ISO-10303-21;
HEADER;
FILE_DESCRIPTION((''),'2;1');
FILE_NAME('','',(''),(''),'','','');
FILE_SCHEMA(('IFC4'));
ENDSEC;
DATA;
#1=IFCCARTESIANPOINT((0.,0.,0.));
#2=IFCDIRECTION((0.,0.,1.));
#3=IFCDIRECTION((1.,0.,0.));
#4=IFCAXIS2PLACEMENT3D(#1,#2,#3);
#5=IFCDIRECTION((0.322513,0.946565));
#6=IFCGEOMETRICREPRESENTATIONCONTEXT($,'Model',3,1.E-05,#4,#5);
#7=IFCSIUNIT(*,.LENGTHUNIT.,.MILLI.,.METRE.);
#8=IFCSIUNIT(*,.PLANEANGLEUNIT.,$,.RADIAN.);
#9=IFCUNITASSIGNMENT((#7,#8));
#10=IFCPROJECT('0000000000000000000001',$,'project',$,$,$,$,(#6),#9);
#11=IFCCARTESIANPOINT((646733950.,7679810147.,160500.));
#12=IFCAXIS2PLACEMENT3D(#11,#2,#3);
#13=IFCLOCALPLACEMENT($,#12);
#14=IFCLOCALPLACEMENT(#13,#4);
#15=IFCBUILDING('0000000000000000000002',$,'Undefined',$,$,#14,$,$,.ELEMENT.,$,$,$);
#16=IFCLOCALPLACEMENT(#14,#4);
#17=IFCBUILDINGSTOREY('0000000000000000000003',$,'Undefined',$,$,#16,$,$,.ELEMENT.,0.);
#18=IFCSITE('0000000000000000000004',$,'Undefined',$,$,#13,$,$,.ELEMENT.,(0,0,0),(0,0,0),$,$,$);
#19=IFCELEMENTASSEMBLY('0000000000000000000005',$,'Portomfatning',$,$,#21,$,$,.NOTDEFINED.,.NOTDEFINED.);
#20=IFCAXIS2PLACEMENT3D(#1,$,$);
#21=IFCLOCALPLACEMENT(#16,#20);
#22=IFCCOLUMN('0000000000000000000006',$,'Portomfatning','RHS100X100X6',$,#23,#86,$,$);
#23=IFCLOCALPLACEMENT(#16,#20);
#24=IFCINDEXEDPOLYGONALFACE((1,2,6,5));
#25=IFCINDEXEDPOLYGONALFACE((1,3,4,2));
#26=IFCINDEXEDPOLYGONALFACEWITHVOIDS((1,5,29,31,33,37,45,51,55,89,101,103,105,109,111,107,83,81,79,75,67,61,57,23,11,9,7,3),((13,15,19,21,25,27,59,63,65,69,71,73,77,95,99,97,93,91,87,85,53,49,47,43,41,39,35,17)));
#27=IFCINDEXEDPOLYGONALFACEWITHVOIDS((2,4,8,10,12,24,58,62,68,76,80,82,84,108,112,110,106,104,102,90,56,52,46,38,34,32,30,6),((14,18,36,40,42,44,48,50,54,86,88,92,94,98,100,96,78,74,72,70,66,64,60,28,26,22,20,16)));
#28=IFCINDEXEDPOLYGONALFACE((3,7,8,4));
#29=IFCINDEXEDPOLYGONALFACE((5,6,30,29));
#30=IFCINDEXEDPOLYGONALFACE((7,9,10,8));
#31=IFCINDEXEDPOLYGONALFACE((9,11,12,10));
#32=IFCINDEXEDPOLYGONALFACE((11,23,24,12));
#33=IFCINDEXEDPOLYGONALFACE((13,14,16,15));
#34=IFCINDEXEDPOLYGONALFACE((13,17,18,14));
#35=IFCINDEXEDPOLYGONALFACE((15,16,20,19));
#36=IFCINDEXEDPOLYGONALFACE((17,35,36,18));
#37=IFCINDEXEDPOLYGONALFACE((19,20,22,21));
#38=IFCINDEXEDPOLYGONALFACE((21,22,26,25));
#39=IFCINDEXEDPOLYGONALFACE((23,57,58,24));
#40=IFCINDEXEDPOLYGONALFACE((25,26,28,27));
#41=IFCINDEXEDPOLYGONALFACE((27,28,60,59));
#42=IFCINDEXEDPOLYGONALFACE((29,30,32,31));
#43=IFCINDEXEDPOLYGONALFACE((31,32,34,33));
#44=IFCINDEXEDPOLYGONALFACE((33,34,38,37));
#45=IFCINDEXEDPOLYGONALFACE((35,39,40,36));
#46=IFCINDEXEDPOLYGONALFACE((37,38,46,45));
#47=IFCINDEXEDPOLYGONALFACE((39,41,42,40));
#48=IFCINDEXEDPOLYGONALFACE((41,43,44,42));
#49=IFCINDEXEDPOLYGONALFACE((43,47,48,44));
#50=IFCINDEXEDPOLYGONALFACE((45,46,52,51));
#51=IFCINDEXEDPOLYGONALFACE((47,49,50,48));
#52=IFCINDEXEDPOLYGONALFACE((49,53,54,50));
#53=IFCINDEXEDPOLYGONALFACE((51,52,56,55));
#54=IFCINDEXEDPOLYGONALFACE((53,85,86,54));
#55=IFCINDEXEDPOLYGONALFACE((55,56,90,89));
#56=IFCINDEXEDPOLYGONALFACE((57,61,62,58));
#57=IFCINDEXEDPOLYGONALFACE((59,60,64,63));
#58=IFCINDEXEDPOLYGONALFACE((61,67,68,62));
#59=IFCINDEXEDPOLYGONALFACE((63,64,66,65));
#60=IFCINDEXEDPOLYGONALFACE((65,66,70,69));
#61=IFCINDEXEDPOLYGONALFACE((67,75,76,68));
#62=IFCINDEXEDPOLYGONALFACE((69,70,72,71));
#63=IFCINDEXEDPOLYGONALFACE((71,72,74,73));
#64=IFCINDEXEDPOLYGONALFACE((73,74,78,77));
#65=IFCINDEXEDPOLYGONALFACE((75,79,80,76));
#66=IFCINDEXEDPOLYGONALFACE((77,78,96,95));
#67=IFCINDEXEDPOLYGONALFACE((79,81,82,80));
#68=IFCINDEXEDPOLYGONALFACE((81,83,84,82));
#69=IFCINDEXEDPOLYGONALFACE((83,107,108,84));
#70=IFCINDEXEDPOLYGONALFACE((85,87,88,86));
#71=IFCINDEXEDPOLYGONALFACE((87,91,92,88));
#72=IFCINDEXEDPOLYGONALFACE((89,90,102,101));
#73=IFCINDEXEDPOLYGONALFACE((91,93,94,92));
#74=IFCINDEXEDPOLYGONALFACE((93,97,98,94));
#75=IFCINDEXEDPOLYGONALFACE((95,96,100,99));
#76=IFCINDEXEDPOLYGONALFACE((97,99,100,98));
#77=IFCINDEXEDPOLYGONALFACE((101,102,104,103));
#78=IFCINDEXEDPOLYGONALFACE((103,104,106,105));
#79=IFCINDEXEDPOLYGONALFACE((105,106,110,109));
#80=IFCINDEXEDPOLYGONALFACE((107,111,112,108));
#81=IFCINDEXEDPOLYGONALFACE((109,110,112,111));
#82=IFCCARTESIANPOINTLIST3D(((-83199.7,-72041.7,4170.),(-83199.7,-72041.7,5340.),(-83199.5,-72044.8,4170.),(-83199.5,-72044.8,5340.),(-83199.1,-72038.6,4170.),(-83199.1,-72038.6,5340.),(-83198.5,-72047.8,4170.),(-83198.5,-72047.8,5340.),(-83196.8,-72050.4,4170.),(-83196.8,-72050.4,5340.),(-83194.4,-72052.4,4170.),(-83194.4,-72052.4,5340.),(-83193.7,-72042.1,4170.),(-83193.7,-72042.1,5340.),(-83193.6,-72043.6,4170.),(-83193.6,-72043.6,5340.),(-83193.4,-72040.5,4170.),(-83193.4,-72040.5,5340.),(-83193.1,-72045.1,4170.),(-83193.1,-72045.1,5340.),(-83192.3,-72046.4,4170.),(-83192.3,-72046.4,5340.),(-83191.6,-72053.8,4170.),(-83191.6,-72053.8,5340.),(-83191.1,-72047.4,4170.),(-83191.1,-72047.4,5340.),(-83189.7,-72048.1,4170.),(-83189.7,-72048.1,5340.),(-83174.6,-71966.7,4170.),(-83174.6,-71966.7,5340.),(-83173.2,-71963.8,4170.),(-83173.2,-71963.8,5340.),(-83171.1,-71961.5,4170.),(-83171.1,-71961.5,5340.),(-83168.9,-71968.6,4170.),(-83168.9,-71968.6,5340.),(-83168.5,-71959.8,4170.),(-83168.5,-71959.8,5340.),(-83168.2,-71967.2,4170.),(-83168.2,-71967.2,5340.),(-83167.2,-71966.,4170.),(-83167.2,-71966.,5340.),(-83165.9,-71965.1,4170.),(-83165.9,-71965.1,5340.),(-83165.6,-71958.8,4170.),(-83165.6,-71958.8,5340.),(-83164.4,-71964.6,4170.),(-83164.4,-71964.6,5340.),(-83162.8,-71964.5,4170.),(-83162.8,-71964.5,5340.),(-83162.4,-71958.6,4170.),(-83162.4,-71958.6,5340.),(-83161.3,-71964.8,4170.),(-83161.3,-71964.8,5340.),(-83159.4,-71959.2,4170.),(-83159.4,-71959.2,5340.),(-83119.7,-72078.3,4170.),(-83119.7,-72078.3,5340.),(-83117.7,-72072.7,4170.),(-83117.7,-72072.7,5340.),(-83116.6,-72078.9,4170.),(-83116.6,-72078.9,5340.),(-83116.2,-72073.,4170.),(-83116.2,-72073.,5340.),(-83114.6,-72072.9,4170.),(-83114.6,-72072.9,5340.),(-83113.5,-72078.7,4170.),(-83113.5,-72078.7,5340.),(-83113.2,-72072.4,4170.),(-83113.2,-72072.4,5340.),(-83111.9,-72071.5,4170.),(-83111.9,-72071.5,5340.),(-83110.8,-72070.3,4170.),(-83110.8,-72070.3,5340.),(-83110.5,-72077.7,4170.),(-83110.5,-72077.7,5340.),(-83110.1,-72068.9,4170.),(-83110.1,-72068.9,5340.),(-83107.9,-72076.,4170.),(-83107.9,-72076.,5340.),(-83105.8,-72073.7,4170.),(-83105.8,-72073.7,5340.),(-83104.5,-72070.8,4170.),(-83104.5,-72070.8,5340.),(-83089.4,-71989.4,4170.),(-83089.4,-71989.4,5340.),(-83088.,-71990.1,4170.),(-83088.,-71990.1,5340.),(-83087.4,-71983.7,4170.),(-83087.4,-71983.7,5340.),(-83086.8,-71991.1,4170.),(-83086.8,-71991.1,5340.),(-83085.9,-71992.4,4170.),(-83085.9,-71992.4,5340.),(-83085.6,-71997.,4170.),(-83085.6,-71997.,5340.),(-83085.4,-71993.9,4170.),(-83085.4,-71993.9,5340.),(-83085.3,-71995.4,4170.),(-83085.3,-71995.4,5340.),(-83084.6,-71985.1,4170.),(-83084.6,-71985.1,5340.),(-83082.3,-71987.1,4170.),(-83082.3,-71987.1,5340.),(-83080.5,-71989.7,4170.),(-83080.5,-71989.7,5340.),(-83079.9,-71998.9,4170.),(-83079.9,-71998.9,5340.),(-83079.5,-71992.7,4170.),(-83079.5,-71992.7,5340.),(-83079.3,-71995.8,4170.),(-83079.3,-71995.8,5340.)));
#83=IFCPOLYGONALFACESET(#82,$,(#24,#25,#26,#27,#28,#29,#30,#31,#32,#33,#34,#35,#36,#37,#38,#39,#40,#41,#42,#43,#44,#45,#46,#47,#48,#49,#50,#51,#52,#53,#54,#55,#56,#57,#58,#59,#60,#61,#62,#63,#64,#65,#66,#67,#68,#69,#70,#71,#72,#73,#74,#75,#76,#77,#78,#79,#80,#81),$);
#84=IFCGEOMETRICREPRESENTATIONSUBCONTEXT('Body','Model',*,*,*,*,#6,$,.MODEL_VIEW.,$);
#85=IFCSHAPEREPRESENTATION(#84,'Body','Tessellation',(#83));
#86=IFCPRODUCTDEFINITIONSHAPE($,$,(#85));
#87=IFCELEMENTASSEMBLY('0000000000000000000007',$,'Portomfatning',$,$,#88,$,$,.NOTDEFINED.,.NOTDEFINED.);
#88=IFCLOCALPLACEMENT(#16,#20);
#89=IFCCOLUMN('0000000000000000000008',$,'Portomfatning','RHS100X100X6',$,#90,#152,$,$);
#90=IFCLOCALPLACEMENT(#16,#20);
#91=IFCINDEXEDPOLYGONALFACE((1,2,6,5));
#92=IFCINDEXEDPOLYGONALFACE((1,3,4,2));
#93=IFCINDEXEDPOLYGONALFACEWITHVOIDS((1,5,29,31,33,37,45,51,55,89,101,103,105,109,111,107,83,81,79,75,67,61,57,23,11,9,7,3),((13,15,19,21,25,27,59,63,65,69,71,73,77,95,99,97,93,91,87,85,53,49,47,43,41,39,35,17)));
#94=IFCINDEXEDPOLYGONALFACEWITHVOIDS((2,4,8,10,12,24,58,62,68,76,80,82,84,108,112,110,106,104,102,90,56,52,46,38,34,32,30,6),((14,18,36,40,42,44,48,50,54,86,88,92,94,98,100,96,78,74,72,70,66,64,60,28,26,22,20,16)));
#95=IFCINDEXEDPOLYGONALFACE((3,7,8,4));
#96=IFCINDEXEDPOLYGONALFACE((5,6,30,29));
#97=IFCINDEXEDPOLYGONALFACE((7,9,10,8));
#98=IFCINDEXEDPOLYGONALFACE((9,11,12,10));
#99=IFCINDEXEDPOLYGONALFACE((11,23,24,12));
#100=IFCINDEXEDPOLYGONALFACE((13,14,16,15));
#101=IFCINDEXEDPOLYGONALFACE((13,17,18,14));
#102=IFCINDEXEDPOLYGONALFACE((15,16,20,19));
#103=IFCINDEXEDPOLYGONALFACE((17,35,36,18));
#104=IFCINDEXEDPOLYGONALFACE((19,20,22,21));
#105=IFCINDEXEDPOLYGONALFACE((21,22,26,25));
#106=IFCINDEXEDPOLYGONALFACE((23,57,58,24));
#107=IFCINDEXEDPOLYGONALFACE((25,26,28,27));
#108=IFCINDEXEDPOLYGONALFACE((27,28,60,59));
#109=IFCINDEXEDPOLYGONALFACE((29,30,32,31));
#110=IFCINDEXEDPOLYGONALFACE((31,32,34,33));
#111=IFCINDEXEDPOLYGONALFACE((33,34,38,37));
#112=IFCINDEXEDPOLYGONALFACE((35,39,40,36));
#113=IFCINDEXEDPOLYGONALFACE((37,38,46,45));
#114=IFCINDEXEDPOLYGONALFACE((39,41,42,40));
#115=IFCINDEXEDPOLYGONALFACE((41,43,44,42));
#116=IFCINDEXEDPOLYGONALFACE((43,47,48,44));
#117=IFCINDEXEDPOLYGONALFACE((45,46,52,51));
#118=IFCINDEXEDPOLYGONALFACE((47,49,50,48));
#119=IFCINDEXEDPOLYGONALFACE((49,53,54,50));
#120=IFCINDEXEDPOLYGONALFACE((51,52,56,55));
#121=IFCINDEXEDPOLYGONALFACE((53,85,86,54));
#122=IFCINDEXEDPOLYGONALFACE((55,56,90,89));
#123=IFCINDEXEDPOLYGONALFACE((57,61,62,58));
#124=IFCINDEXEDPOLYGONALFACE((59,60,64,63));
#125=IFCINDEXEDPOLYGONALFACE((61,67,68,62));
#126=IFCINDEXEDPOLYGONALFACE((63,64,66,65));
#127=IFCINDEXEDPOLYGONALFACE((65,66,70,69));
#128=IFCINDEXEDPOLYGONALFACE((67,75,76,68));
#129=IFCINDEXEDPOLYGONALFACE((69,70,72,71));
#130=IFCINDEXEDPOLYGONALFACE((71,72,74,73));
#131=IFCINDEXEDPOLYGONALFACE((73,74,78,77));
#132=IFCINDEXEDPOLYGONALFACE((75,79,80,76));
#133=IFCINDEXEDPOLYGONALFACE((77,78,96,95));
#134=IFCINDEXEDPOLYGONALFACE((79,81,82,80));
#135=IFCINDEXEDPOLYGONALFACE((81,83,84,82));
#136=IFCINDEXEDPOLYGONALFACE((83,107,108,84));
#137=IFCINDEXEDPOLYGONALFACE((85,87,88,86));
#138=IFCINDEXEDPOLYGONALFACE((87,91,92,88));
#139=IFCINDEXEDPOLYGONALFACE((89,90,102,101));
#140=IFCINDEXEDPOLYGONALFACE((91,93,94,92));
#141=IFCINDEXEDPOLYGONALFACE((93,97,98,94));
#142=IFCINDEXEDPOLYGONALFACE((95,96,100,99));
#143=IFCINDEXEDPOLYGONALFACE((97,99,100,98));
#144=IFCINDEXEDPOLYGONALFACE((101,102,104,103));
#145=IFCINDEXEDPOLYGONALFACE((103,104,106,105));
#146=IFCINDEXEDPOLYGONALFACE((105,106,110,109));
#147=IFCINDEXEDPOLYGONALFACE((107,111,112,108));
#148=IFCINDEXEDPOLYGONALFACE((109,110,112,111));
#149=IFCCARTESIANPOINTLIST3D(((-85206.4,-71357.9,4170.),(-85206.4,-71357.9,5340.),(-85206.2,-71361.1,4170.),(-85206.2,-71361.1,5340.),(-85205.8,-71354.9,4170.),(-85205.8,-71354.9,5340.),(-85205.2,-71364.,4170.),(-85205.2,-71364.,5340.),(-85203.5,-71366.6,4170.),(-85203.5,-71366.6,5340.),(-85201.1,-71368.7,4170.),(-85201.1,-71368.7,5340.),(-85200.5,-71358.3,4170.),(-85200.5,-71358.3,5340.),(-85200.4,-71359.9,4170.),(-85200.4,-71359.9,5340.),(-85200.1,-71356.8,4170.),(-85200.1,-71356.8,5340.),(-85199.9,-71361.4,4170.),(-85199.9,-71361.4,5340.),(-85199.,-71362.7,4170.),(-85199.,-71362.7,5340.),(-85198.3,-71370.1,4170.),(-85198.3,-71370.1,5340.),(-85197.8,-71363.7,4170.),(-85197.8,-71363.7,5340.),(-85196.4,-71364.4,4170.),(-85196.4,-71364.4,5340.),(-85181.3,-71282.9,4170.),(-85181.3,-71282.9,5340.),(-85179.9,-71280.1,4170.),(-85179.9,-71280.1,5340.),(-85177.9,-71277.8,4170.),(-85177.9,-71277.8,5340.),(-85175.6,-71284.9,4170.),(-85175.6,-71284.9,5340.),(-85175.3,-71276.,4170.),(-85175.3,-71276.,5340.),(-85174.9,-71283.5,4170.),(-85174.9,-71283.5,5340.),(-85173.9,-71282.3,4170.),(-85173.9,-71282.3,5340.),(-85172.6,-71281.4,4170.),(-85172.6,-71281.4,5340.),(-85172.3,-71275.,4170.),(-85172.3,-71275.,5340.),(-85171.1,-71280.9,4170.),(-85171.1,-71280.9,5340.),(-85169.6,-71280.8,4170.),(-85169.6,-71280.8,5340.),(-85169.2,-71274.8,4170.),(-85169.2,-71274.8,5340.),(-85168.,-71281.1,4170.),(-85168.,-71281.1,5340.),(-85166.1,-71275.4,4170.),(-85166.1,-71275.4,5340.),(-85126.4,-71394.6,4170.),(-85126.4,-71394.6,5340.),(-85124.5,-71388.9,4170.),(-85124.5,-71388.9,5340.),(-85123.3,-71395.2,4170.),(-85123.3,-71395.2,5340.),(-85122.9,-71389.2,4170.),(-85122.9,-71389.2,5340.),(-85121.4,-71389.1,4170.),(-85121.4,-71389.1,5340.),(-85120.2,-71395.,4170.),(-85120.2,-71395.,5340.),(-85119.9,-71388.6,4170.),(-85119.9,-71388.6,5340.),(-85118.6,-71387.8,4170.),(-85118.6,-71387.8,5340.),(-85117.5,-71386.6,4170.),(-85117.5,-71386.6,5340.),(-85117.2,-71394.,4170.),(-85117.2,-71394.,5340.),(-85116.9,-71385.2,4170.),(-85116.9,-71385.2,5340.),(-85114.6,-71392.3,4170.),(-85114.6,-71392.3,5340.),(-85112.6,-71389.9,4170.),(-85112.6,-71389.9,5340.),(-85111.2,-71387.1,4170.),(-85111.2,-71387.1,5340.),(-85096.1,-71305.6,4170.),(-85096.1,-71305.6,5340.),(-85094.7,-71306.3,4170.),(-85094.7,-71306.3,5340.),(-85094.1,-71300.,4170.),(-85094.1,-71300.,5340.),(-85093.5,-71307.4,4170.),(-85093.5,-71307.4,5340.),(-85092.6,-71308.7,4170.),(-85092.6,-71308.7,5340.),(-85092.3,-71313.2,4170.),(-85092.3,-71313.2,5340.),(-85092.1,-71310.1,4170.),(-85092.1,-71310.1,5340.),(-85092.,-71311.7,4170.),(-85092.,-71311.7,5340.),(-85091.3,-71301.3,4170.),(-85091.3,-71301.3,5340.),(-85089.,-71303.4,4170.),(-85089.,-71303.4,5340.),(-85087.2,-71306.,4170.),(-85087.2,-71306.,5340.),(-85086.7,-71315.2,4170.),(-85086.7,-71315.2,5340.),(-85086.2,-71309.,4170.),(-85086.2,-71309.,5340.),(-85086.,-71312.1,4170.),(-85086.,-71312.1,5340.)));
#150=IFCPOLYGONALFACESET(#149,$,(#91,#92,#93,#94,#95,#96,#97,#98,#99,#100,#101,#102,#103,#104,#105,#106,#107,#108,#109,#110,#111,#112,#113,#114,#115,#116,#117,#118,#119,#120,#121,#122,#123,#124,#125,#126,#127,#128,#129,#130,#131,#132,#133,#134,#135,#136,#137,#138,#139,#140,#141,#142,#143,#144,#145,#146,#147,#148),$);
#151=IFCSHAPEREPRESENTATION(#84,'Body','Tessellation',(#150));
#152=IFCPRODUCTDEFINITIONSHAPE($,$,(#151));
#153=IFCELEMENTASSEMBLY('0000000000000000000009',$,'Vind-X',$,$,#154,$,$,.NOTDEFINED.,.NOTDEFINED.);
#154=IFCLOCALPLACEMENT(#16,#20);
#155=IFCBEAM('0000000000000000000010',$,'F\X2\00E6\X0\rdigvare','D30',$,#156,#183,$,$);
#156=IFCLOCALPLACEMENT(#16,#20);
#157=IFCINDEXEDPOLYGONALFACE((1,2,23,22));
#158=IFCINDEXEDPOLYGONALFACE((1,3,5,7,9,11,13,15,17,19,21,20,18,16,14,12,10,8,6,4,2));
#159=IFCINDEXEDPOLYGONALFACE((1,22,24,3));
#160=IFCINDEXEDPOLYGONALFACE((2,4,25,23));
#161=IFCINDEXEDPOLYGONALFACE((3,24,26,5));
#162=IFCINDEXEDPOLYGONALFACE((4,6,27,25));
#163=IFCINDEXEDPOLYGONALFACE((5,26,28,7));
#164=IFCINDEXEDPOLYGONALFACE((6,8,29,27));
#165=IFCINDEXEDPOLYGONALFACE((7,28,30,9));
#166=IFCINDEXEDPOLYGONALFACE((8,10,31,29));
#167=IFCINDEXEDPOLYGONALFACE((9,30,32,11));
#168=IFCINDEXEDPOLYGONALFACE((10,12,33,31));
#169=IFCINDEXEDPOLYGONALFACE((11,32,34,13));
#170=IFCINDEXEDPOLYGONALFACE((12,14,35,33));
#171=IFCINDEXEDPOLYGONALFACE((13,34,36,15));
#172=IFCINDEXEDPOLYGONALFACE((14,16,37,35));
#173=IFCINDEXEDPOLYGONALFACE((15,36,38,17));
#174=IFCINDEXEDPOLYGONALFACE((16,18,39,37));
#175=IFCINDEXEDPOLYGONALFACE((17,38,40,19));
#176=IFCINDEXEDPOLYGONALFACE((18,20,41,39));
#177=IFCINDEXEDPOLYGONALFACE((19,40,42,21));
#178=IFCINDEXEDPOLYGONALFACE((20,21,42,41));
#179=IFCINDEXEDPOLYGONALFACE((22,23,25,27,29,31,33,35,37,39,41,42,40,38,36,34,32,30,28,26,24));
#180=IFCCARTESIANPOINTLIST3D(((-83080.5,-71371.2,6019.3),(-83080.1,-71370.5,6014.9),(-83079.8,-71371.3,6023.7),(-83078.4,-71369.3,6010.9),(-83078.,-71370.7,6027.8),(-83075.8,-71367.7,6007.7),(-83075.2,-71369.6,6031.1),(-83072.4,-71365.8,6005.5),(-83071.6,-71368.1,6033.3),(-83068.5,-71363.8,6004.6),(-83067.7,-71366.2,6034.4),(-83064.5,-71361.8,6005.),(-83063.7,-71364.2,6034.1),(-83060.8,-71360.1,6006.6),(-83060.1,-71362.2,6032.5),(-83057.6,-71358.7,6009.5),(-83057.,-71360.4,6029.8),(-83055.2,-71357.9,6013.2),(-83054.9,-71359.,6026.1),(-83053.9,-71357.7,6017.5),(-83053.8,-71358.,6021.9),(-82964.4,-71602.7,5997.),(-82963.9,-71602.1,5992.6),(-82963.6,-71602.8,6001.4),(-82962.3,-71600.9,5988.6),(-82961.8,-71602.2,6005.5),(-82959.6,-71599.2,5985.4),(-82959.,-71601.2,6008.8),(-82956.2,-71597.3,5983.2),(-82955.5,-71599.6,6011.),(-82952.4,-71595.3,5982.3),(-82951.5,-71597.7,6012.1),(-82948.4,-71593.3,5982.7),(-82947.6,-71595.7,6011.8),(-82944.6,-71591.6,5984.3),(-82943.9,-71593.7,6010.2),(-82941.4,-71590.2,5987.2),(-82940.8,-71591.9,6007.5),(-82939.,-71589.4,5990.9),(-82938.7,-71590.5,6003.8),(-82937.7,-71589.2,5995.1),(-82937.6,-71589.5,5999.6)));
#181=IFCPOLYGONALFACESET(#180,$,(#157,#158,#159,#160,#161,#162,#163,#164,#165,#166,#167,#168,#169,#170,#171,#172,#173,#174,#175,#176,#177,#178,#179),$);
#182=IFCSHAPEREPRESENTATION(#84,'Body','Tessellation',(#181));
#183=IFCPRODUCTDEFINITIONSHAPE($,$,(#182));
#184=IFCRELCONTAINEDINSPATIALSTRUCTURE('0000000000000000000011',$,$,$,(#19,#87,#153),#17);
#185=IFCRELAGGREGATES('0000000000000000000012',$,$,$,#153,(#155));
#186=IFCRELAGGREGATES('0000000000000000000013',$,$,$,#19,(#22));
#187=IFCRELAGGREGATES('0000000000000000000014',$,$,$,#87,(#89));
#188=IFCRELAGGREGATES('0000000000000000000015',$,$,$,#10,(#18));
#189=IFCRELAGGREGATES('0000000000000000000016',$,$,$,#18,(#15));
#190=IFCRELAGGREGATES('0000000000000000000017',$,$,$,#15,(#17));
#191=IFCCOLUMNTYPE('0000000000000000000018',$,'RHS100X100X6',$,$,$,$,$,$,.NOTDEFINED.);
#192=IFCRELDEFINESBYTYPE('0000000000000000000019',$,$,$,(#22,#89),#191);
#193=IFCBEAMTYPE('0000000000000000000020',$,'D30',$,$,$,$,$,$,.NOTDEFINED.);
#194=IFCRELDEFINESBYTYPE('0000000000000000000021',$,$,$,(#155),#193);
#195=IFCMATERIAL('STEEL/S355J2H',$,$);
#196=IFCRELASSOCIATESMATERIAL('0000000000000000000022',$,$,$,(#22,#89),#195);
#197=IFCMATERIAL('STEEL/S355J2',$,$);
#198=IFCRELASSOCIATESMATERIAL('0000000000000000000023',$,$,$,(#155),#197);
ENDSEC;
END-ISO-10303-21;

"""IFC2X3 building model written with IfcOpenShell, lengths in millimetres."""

from ifc_helpers import new_model, si_unit, direction, frame, origin_with_axes, origin_2d_with_axis, place, context, subcontext, project, spatial, hollow_rectangle, circle, extrude, clip, halfspace, material, type_object, element, aggregate, save


model = new_model("IFC2X3")

# Units and contexts
model_context = context("Model", 3, precision=1e-05, world=origin_with_axes(), true_north=direction((0.322513, 0.946565)))
body_context = subcontext(model_context, "Body", "Model", "MODEL_VIEW")
ifc_project = project(units=[si_unit("LENGTHUNIT", "METRE", prefix="MILLI"), si_unit("PLANEANGLEUNIT", "RADIAN")], contexts=[model_context])

# Site, building, storey
site_placement = place(None, frame((646733950.0, 7679810147.0, 160500.0), z_axis=(0.0, 0.0, 1.0), x_axis=(1.0, 0.0, 0.0)))
site = spatial("IfcSite", under=ifc_project, at=site_placement, Name="Undefined", CompositionType="ELEMENT", RefLatitude=(0, 0, 0), RefLongitude=(0, 0, 0))
building_placement = place(site_placement, origin_with_axes())
building = spatial("IfcBuilding", under=site, at=building_placement, Name="Undefined", CompositionType="ELEMENT")
storey_placement = place(building_placement, origin_with_axes())
storey = spatial("IfcBuildingStorey", under=building, at=storey_placement, Name="Undefined", CompositionType="ELEMENT", Elevation=0.0)

# Element assemblies, columns
assembly_1_placement = place(storey_placement, origin_with_axes())
assembly_1 = element("IfcElementAssembly", 1, at=assembly_1_placement, inside=storey, Name="Portomfatning", AssemblyPlace="NOTDEFINED", PredefinedType="NOTDEFINED")
ifc_material_1 = material(Name="STEEL/S355J2H")
column_type = type_object("IfcColumnType", Name="RHS100X100X6", PredefinedType="NOTDEFINED")
column_1_placement = place(assembly_1_placement, frame((-83139.5, -72018.8, 4160.0), z_axis=(0.0, 0.0, 1.0), x_axis=(-0.322513, -0.946565, 0.0)))
column_1 = element("IfcColumn", 2, at=column_1_placement, type_object=column_type, material=ifc_material_1, Name="Portomfatning", Description="RHS100X100X6", context=body_context, shape_type="Clipping", body=[
    clip(clip(extrude(hollow_rectangle(XDim=100.0, YDim=100.0, WallThickness=6.0, InnerFilletRadius=6.0, OuterFilletRadius=12.0, at=origin_2d_with_axis()), frame((0.0, 0.0, 1190.0), z_axis=(0.0, 0.0, -1.0), x_axis=(0.0, 1.0, 0.0)), (0.0, 0.0, 1.0), 1190.0), halfspace(frame((0.0, -50.0, 1180.0), z_axis=(0.0, 0.0, -1.0), x_axis=(1.0, 0.0, 0.0)), True)), halfspace(frame((0.0, -50.0, 10.0), z_axis=(0.0, 0.0, 1.0), x_axis=(-1.0, 0.0, 0.0)), True)),
])
assembly_2_placement = place(storey_placement, origin_with_axes())
assembly_2 = element("IfcElementAssembly", 3, at=assembly_2_placement, inside=storey, Name="Portomfatning", AssemblyPlace="NOTDEFINED", PredefinedType="NOTDEFINED")
column_2_placement = place(assembly_2_placement, frame((-85146.2, -71335.0, 4160.0), z_axis=(0.0, 0.0, 1.0), x_axis=(-0.322513, -0.946565, 0.0)))
column_2 = element("IfcColumn", 4, at=column_2_placement, type_object=column_type, material=ifc_material_1, Name="Portomfatning", Description="RHS100X100X6", context=body_context, shape_type="Clipping", body=[
    clip(clip(extrude(hollow_rectangle(XDim=100.0, YDim=100.0, WallThickness=6.0, InnerFilletRadius=6.0, OuterFilletRadius=12.0, at=origin_2d_with_axis()), frame((0.0, 0.0, 1190.0), z_axis=(0.0, 0.0, -1.0), x_axis=(0.0, 1.0, 0.0)), (0.0, 0.0, 1.0), 1190.0), halfspace(frame((0.0, 50.0, 1180.0), z_axis=(0.0, 0.0, -1.0), x_axis=(-1.0, 0.0, 0.0)), True)), halfspace(frame((0.0, 50.0, 10.0), z_axis=(0.0, 0.0, 1.0), x_axis=(1.0, 0.0, 0.0)), True)),
])

# Element assembly, beam
assembly_3_placement = place(storey_placement, origin_with_axes())
assembly_3 = element("IfcElementAssembly", 5, at=assembly_3_placement, inside=storey, Name="Vind-X", AssemblyPlace="NOTDEFINED", PredefinedType="NOTDEFINED")
ifc_material_2 = material(Name="STEEL/S355J2")
beam_type_1 = type_object("IfcBeamType", Name="D30", PredefinedType="NOTDEFINED")
beam_1_placement = place(assembly_3_placement, frame((-82950.9, -71596.0, 5997.2), z_axis=(-0.893742, -0.440153, -0.086548), x_axis=(-0.446856, 0.890482, 0.0858)))
beam_1 = element("IfcBeam", 6, at=beam_1_placement, type_object=beam_type_1, material=ifc_material_2, Name="Færdigvare", Description="D30", context=body_context, shape_type="SweptSolid", body=[
    extrude(circle(Radius=15.0, at=origin_2d_with_axis()), frame((260.0, 0.0, 0.0), z_axis=(-1.0, 0.0, 0.0), x_axis=(0.0, -1.0, 0.0)), (0.0, 0.0, 1.0), 260.0),
])

aggregate(assembly_3, [beam_1])
aggregate(assembly_1, [column_1])
aggregate(assembly_2, [column_2])

save(model, "model.ifc")
